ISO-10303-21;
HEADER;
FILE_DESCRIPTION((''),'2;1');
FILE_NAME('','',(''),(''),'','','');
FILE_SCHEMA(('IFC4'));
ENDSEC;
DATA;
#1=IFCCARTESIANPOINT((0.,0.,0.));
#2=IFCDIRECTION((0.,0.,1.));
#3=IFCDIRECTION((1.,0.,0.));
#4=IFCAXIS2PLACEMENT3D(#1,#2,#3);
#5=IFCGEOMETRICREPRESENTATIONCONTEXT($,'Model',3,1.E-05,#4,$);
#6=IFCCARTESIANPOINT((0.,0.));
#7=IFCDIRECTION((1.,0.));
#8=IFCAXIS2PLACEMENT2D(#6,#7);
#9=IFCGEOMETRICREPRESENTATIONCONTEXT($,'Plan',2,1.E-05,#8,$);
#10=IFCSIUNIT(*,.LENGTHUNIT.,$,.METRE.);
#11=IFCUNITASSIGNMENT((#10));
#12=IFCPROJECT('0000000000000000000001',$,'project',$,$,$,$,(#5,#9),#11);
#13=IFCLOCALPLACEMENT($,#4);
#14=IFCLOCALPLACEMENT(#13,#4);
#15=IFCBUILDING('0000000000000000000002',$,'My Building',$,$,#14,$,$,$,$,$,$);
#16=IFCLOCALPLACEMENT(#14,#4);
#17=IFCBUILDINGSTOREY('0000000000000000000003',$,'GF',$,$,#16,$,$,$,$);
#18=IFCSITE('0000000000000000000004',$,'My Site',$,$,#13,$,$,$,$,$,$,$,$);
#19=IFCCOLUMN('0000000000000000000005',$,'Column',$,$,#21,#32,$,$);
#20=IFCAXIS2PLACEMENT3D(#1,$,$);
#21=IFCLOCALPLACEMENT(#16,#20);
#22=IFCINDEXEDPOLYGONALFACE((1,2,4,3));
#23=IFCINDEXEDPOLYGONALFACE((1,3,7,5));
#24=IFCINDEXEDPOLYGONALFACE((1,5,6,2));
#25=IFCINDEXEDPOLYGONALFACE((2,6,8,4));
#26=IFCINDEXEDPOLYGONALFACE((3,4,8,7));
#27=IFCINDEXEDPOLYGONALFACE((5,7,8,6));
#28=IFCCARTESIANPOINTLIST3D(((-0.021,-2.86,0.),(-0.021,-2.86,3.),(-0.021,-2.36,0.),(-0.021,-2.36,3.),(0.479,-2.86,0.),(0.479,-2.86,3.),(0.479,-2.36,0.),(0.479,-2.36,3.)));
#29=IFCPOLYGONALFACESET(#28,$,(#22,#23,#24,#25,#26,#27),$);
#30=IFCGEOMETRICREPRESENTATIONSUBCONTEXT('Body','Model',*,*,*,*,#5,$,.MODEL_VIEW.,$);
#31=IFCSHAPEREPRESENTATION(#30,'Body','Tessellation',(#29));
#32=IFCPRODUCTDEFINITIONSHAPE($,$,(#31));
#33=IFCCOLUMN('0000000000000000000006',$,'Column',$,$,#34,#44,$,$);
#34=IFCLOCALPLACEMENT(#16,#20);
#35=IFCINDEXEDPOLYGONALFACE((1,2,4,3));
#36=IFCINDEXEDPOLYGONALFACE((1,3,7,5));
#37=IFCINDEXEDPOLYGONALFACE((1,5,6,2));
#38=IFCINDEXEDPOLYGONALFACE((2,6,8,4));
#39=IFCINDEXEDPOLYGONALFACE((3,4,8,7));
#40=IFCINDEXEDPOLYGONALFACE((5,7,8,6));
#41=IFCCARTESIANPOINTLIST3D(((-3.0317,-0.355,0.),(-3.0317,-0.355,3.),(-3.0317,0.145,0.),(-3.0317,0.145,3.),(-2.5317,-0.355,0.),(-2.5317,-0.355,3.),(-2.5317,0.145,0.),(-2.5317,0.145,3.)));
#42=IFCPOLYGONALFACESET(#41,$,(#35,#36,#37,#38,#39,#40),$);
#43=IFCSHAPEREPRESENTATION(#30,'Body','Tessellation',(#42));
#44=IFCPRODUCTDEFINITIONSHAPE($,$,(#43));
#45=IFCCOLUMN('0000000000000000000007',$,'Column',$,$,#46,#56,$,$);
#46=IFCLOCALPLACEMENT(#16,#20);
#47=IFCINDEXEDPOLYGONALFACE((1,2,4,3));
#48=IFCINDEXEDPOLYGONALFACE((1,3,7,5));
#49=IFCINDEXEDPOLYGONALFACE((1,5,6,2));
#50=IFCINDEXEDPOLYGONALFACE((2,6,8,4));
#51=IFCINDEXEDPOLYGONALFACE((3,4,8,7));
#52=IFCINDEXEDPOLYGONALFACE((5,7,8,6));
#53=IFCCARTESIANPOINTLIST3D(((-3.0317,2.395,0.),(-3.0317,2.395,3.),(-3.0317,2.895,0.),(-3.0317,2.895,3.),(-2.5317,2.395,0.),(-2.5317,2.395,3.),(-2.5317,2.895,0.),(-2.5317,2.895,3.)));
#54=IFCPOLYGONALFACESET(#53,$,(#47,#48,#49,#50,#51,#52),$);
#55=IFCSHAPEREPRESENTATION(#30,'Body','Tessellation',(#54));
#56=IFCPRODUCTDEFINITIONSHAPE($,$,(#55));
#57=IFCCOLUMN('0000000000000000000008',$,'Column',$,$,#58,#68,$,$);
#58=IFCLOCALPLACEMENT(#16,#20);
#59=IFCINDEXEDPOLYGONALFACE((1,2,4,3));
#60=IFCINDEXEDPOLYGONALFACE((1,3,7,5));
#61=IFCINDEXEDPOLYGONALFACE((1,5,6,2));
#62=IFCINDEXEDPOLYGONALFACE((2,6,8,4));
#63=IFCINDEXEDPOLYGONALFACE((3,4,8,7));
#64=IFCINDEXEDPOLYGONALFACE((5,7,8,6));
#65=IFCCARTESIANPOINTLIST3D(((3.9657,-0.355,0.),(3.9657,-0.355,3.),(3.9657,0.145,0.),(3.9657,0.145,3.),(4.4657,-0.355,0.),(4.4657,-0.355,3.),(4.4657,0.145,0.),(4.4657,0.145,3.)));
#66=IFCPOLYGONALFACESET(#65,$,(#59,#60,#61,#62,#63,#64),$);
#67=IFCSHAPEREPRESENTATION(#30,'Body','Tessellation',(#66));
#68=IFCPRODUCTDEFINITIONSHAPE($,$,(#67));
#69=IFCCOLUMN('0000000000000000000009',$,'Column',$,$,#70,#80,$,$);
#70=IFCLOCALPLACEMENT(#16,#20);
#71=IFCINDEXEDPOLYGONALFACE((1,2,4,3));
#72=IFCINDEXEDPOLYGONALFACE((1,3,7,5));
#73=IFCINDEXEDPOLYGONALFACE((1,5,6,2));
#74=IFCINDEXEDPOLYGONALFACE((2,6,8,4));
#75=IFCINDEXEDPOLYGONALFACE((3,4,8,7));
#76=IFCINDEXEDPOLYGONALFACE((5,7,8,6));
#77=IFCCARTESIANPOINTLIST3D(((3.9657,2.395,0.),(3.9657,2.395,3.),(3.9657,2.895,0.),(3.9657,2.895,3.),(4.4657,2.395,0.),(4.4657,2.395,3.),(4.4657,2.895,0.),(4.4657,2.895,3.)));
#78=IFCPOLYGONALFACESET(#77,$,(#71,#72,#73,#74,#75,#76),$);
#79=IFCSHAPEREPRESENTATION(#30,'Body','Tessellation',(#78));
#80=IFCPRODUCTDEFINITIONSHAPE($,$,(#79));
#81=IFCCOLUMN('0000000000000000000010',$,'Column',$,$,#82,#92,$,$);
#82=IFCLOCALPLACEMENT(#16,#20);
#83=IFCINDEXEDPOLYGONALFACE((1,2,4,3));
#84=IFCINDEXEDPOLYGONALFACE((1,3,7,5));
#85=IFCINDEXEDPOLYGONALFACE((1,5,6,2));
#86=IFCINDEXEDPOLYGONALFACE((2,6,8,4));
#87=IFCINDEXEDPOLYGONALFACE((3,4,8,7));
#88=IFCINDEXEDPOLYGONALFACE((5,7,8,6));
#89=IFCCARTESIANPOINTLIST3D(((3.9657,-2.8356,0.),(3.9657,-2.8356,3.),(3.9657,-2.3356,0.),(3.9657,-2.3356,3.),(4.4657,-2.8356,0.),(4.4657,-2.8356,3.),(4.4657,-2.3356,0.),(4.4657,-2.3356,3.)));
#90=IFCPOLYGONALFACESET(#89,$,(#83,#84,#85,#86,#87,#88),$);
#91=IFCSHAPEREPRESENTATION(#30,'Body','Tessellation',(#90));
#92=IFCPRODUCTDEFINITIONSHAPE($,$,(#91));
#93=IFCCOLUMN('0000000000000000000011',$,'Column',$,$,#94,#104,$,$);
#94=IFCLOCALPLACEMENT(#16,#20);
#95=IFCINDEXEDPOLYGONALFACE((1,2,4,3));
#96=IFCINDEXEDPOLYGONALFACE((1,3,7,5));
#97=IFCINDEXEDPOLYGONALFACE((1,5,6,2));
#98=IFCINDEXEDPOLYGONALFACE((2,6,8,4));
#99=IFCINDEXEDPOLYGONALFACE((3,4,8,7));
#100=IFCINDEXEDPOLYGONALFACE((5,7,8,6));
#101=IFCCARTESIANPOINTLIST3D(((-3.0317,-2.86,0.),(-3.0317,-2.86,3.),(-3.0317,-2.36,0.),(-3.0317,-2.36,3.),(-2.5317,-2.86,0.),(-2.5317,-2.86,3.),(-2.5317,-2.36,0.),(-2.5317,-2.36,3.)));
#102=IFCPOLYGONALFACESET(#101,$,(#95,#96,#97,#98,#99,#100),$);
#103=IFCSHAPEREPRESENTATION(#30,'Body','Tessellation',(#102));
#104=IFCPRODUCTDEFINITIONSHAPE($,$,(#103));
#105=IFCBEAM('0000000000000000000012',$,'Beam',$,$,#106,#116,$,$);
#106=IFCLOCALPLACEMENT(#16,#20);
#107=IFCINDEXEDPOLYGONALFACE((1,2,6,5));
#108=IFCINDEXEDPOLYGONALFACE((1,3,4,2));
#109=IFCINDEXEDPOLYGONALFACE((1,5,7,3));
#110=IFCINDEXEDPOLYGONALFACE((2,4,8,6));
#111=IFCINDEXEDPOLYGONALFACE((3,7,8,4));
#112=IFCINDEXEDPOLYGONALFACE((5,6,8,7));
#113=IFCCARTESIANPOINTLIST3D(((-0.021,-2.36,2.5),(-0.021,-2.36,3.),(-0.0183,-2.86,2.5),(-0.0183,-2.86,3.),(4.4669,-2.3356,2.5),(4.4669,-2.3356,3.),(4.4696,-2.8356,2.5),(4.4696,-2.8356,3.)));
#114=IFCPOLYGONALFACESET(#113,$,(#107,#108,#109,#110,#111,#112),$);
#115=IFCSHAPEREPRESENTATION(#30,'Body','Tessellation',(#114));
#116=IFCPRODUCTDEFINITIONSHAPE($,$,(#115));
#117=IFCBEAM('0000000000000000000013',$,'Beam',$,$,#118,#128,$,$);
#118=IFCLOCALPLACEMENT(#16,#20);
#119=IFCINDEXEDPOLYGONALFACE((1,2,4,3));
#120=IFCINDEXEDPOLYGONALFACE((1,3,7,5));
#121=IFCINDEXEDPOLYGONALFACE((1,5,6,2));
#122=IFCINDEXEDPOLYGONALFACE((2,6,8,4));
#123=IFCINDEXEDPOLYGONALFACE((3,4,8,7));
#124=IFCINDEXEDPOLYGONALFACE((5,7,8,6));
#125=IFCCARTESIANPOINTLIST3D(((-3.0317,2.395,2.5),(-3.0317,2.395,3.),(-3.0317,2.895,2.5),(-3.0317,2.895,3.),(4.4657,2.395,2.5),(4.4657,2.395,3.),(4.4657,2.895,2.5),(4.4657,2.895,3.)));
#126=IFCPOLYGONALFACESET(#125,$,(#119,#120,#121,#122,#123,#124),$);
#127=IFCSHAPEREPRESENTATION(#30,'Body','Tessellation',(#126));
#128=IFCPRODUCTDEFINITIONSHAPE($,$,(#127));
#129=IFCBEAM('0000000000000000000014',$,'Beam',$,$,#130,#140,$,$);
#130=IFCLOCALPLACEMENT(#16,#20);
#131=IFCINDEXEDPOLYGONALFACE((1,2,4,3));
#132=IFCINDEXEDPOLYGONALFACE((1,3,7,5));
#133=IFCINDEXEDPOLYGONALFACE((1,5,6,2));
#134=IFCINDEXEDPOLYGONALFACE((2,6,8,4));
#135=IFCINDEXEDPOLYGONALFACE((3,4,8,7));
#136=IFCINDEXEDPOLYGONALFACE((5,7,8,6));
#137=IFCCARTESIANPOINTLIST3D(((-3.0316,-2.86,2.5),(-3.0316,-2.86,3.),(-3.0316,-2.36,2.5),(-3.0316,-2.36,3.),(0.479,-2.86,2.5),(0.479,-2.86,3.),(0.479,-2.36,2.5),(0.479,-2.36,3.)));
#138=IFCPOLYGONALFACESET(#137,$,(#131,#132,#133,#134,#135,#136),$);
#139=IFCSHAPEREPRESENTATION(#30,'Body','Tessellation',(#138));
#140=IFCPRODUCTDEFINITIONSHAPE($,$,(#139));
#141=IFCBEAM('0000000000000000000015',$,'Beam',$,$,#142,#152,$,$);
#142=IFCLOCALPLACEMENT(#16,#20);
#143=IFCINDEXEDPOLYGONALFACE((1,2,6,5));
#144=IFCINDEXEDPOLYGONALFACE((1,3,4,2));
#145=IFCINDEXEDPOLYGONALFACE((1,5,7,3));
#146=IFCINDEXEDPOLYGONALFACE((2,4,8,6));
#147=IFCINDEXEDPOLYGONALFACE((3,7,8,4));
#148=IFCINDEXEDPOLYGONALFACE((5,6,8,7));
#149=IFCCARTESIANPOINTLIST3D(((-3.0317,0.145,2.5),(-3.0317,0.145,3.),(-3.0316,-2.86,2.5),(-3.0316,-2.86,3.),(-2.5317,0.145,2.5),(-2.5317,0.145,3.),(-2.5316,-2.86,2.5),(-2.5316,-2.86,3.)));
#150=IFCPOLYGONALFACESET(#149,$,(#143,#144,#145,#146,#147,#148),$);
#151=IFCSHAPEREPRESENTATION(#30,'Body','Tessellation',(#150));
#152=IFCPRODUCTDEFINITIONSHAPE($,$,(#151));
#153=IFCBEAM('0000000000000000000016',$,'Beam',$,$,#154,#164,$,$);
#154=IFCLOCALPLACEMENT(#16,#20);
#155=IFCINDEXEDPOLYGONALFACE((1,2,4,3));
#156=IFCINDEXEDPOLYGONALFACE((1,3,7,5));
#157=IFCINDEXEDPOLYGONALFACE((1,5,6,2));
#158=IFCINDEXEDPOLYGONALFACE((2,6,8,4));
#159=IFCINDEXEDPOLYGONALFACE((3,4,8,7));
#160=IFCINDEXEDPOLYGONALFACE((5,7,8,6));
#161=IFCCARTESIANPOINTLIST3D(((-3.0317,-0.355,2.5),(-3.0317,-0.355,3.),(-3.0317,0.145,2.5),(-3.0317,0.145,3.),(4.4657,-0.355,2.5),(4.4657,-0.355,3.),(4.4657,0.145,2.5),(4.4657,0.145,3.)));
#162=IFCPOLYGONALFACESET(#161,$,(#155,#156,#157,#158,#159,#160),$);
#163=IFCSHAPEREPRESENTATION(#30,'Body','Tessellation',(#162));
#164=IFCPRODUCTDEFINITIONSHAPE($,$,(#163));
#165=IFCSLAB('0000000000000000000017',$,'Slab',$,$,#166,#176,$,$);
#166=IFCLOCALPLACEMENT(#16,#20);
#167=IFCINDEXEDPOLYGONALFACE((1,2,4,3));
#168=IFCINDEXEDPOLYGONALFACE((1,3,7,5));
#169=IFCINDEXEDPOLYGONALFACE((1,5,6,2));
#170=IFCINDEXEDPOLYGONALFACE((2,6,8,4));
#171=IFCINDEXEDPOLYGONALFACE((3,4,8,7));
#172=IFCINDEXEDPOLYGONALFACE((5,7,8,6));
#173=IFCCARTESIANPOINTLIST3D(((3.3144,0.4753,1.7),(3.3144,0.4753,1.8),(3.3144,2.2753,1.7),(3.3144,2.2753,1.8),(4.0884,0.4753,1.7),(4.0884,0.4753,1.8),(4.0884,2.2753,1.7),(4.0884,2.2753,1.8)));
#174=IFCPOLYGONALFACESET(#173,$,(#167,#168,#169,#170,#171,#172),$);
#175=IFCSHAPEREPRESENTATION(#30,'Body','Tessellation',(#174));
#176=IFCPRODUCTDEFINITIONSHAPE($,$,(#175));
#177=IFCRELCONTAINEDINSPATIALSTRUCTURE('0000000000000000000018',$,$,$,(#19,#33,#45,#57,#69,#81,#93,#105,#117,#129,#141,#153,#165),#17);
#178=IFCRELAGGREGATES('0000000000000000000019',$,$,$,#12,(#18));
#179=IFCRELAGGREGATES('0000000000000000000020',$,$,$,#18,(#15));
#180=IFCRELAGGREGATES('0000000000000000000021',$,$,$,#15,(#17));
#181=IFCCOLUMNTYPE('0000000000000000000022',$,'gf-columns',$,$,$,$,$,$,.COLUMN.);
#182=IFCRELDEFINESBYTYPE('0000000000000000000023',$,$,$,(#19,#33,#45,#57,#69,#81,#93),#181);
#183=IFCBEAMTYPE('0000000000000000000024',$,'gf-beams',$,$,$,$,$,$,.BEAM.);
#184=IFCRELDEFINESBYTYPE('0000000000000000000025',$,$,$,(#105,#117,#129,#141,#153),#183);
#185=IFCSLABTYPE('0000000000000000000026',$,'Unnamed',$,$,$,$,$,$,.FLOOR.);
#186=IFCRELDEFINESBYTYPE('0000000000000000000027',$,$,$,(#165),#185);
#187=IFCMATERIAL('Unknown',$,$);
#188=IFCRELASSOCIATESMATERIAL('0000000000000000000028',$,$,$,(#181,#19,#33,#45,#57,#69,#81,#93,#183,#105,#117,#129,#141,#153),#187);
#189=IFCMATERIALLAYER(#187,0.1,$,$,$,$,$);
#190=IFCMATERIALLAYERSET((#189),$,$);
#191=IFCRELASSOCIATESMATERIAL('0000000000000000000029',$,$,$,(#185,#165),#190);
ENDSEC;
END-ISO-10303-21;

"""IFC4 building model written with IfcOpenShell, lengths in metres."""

from ifc_helpers import new_model, si_unit, frame, origin_with_axes, origin_2d_with_axis, place, context, subcontext, project, spatial, indexed_curve, rectangle, outline, extrude, material, layer, layer_set, layer_usage, material_profile, profile_set, profile_usage, type_object, element, save


model = new_model("IFC4")

# Units and contexts
model_context = context("Model", 3, precision=1e-05, world=origin_with_axes())
plan_context = context("Plan", 2, precision=1e-05, world=origin_2d_with_axis())
body_context_1 = subcontext(model_context, "Body", "Model", "MODEL_VIEW")
ifc_project = project(units=[si_unit("LENGTHUNIT", "METRE")], contexts=[model_context, plan_context])

# Site, building, storey
site_placement = place(None, origin_with_axes())
site = spatial("IfcSite", under=ifc_project, at=site_placement, Name="My Site")
building_placement = place(site_placement, origin_with_axes())
building = spatial("IfcBuilding", under=site, at=building_placement, Name="My Building")
storey_placement = place(building_placement, origin_with_axes())
storey = spatial("IfcBuildingStorey", under=building, at=storey_placement, Name="GF")

# Columns
ifc_material = material(Name="Unknown")
ifc_material_profile_1 = material_profile(ifc_material, rectangle(XDim=0.5, YDim=0.5))
ifc_profile_set_1 = profile_set([ifc_material_profile_1])
ifc_profile_usage_1 = profile_usage(ifc_profile_set_1, cardinal=5)
column_type = type_object("IfcColumnType", Name="gf-columns", PredefinedType="COLUMN", material=ifc_profile_set_1)
column_1_placement = place(storey_placement, frame((0.229, -2.61, 0.0), z_axis=(0.0, 0.0, 1.0), x_axis=(1.0, 0.0, 0.0)))
element("IfcColumn", 1, at=column_1_placement, inside=storey, type_object=column_type, material=ifc_profile_usage_1, Name="Column", context=body_context_1, shape_type="SweptSolid", body=[
    extrude(rectangle(XDim=0.5, YDim=0.5), origin_with_axes(), (0.0, 0.0, 1.0), 3.0),
])
ifc_profile_usage_2 = profile_usage(ifc_profile_set_1, cardinal=5)
column_2_placement = place(storey_placement, frame((-2.7817, -0.105, 0.0), z_axis=(0.0, 0.0, 1.0), x_axis=(1.0, 0.0, 0.0)))
element("IfcColumn", 2, at=column_2_placement, inside=storey, type_object=column_type, material=ifc_profile_usage_2, Name="Column", context=body_context_1, shape_type="SweptSolid", body=[
    extrude(rectangle(XDim=0.5, YDim=0.5), origin_with_axes(), (0.0, 0.0, 1.0), 3.0),
])
ifc_profile_usage_3 = profile_usage(ifc_profile_set_1, cardinal=5)
column_3_placement = place(storey_placement, frame((-2.7817, 2.645, 0.0), z_axis=(0.0, 0.0, 1.0), x_axis=(1.0, 0.0, 0.0)))
element("IfcColumn", 3, at=column_3_placement, inside=storey, type_object=column_type, material=ifc_profile_usage_3, Name="Column", context=body_context_1, shape_type="SweptSolid", body=[
    extrude(rectangle(XDim=0.5, YDim=0.5), origin_with_axes(), (0.0, 0.0, 1.0), 3.0),
])
ifc_profile_usage_4 = profile_usage(ifc_profile_set_1, cardinal=5)
column_4_placement = place(storey_placement, frame((4.2157, -0.105, 0.0), z_axis=(0.0, 0.0, 1.0), x_axis=(1.0, 0.0, 0.0)))
element("IfcColumn", 4, at=column_4_placement, inside=storey, type_object=column_type, material=ifc_profile_usage_4, Name="Column", context=body_context_1, shape_type="SweptSolid", body=[
    extrude(rectangle(XDim=0.5, YDim=0.5), origin_with_axes(), (0.0, 0.0, 1.0), 3.0),
])
ifc_profile_usage_5 = profile_usage(ifc_profile_set_1, cardinal=5)
column_5_placement = place(storey_placement, frame((4.2157, 2.645, 0.0), z_axis=(0.0, 0.0, 1.0), x_axis=(1.0, 0.0, 0.0)))
element("IfcColumn", 5, at=column_5_placement, inside=storey, type_object=column_type, material=ifc_profile_usage_5, Name="Column", context=body_context_1, shape_type="SweptSolid", body=[
    extrude(rectangle(XDim=0.5, YDim=0.5), origin_with_axes(), (0.0, 0.0, 1.0), 3.0),
])
ifc_profile_usage_6 = profile_usage(ifc_profile_set_1, cardinal=7)
column_6_placement = place(storey_placement, frame((3.9657, -2.8356, 0.0), z_axis=(0.0, 0.0, 1.0), x_axis=(-1.0, 0.0, 0.0)))
element("IfcColumn", 6, at=column_6_placement, inside=storey, type_object=column_type, material=ifc_profile_usage_6, Name="Column", context=body_context_1, shape_type="SweptSolid", body=[
    extrude(rectangle(XDim=0.5, YDim=0.5), frame((-0.25, -0.25, 0.0), z_axis=(0.0, 0.0, 1.0), x_axis=(1.0, 0.0, 0.0)), (0.0, 0.0, 1.0), 3.0),
])
ifc_profile_usage_7 = profile_usage(ifc_profile_set_1, cardinal=5)
column_7_placement = place(storey_placement, frame((-2.7817, -2.61, 0.0), z_axis=(0.0, 0.0, 1.0), x_axis=(1.0, 0.0, 0.0)))
element("IfcColumn", 7, at=column_7_placement, inside=storey, type_object=column_type, material=ifc_profile_usage_7, Name="Column", context=body_context_1, shape_type="SweptSolid", body=[
    extrude(rectangle(XDim=0.5, YDim=0.5), origin_with_axes(), (0.0, 0.0, 1.0), 3.0),
])

# Beams
ifc_material_profile_2 = material_profile(ifc_material, rectangle(XDim=0.5, YDim=0.5))
ifc_profile_set_2 = profile_set([ifc_material_profile_2])
ifc_profile_usage_8 = profile_usage(ifc_profile_set_2, cardinal=7)
beam_type = type_object("IfcBeamType", Name="gf-beams", PredefinedType="BEAM", material=ifc_profile_set_2)
beam_1_placement = place(storey_placement, frame((-0.021, -2.36, 3.0), z_axis=(0.999985, 0.005446, 0.0), x_axis=(-0.005446, 0.999985, 0.0)))
element("IfcBeam", 8, at=beam_1_placement, inside=storey, type_object=beam_type, material=ifc_profile_usage_8, Name="Beam", context=body_context_1, shape_type="SweptSolid", body=[
    extrude(rectangle(XDim=0.5, YDim=0.5), frame((-0.25, -0.25, 0.0), z_axis=(0.0, 0.0, 1.0), x_axis=(1.0, 0.0, 0.0)), (0.0, 0.0, 1.0), 4.488),
])
ifc_profile_usage_9 = profile_usage(ifc_profile_set_2, cardinal=7)
beam_2_placement = place(storey_placement, frame((-3.0317, 2.895, 3.0), z_axis=(1.0, 0.0, 0.0), x_axis=(0.0, 1.0, 0.0)))
element("IfcBeam", 9, at=beam_2_placement, inside=storey, type_object=beam_type, material=ifc_profile_usage_9, Name="Beam", context=body_context_1, shape_type="SweptSolid", body=[
    extrude(rectangle(XDim=0.5, YDim=0.5), frame((-0.25, -0.25, 0.0), z_axis=(0.0, 0.0, 1.0), x_axis=(1.0, 0.0, 0.0)), (0.0, 0.0, 1.0), 7.4974),
])
ifc_profile_usage_10 = profile_usage(ifc_profile_set_2, cardinal=7)
beam_3_placement = place(storey_placement, frame((0.479, -2.86, 3.0), z_axis=(-1.0, 0.0, 0.0), x_axis=(0.0, -1.0, 0.0)))
element("IfcBeam", 10, at=beam_3_placement, inside=storey, type_object=beam_type, material=ifc_profile_usage_10, Name="Beam", context=body_context_1, shape_type="SweptSolid", body=[
    extrude(rectangle(XDim=0.5, YDim=0.5), frame((-0.25, -0.25, 0.0), z_axis=(0.0, 0.0, 1.0), x_axis=(1.0, 0.0, 0.0)), (0.0, 0.0, 1.0), 3.5106),
])
ifc_profile_usage_11 = profile_usage(ifc_profile_set_2, cardinal=7)
beam_4_placement = place(storey_placement, frame((-3.0316, -2.86, 3.0), z_axis=(0.0, 1.0, 0.0), x_axis=(-1.0, 0.0, 0.0)))
element("IfcBeam", 11, at=beam_4_placement, inside=storey, type_object=beam_type, material=ifc_profile_usage_11, Name="Beam", context=body_context_1, shape_type="SweptSolid", body=[
    extrude(rectangle(XDim=0.5, YDim=0.5), frame((-0.25, -0.25, 0.0), z_axis=(0.0, 0.0, 1.0), x_axis=(1.0, 0.0, 0.0)), (0.0, 0.0, 1.0), 3.005),
])
ifc_profile_usage_12 = profile_usage(ifc_profile_set_2, cardinal=7)
beam_5_placement = place(storey_placement, frame((-3.0317, 0.145, 3.0), z_axis=(1.0, -0.000001, 0.0), x_axis=(0.000001, 1.0, 0.0)))
element("IfcBeam", 12, at=beam_5_placement, inside=storey, type_object=beam_type, material=ifc_profile_usage_12, Name="Beam", context=body_context_1, shape_type="SweptSolid", body=[
    extrude(rectangle(XDim=0.5, YDim=0.5), frame((-0.25, -0.25, 0.0), z_axis=(0.0, 0.0, 1.0), x_axis=(1.0, 0.0, 0.0)), (0.0, 0.0, 1.0), 7.4974),
])

# Slab
ifc_layer_1 = layer(ifc_material, 0.1)
ifc_layer_set_1 = layer_set([ifc_layer_1])
ifc_layer_usage_1 = layer_usage(ifc_layer_set_1, "AXIS3", "POSITIVE", -0.1)
slab_type = type_object("IfcSlabType", Name="Unnamed", PredefinedType="FLOOR", material=ifc_layer_set_1)
slab_placement = place(storey_placement, frame((3.3144, 0.4753, 1.8), z_axis=(0.0, 0.0, 1.0), x_axis=(1.0, 0.0, 0.0)))
element("IfcSlab", 13, at=slab_placement, inside=storey, type_object=slab_type, material=ifc_layer_usage_1, Name="Slab", context=body_context_1, shape_type="SweptSolid", body=[
    extrude(outline(indexed_curve([(0.0, 0.0), (0.774, 0.0), (0.774, 1.8), (0.0, 1.8), (0.0, 0.0)])), frame((0.0, 0.0, -0.1), z_axis=(0.0, 0.0, 1.0), x_axis=(1.0, 0.0, 0.0)), (0.0, 0.0, 1.0), 0.1),
])

save(model, "model.ifc")
